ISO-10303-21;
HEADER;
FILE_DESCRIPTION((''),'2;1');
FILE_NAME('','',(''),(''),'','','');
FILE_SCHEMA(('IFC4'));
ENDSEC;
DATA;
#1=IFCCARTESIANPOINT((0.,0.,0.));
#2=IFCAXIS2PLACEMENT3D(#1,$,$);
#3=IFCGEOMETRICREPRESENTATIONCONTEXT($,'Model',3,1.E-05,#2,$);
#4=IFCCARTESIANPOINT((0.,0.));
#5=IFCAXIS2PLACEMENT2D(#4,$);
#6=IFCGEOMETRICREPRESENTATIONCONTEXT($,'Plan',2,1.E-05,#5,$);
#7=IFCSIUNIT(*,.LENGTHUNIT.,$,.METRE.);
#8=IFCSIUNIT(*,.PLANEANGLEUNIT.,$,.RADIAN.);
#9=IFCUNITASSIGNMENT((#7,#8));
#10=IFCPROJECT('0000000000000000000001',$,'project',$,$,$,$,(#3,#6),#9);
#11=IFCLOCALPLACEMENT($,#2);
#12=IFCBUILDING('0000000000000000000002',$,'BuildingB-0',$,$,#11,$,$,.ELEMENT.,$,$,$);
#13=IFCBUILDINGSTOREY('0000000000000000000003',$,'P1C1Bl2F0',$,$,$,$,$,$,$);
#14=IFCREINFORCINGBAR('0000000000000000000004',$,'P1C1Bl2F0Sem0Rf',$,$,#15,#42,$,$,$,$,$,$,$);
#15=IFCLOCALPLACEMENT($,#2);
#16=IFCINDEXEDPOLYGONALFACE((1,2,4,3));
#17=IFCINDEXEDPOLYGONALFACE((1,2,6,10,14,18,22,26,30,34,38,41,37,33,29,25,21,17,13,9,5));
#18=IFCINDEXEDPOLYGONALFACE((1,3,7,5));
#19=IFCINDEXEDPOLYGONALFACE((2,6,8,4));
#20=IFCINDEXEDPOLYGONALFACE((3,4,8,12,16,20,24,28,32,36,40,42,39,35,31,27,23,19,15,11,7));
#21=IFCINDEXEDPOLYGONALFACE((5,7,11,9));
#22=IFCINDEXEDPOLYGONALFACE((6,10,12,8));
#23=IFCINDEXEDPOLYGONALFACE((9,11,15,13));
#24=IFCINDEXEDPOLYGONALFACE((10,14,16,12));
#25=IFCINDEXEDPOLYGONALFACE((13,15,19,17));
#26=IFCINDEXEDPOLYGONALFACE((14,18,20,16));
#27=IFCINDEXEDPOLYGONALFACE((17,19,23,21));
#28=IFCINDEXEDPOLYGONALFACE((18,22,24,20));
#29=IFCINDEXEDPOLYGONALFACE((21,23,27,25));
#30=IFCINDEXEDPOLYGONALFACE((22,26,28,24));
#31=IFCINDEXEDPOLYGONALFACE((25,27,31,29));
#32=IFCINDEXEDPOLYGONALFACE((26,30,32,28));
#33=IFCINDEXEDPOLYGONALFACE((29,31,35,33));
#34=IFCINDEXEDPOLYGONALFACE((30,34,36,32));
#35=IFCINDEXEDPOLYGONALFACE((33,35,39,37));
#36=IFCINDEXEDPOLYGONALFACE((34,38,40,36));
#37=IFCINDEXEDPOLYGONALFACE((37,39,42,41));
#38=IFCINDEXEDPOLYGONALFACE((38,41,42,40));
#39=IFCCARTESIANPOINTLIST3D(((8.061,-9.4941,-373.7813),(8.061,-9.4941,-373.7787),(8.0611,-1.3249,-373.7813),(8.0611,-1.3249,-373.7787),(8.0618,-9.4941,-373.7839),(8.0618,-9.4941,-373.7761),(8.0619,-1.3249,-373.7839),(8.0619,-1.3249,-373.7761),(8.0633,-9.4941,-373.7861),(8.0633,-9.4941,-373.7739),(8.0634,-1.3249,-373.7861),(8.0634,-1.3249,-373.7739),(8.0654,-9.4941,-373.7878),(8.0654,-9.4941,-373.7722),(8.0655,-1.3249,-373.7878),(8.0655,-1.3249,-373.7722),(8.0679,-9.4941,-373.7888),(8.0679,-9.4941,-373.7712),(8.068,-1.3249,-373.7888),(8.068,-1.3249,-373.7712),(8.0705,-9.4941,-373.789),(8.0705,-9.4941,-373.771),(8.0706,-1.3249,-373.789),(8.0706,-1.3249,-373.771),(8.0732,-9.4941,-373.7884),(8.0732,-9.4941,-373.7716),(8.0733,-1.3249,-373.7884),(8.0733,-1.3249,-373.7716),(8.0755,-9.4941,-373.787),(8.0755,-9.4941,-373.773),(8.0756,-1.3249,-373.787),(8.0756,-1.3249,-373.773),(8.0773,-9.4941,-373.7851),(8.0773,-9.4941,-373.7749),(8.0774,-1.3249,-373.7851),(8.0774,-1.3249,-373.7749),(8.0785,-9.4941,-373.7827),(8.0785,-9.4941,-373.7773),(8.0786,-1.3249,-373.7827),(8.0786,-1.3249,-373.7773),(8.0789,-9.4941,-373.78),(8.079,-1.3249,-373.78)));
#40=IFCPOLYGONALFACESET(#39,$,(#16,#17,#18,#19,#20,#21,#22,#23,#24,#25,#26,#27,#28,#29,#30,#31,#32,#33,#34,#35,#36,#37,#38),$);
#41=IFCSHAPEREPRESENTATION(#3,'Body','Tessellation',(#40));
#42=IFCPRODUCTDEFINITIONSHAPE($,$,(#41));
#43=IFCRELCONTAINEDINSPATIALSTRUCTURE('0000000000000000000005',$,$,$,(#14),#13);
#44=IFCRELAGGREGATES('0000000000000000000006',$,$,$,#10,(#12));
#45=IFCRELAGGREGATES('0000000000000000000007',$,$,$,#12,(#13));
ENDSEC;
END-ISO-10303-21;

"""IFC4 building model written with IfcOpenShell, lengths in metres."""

from ifc_helpers import new_model, entity, si_unit, origin, origin_2d, place, context, project, spatial, element, save


model = new_model("IFC4")

# Units and contexts
model_context = context("Model", 3, precision=1e-05, world=origin())
plan_context = context("Plan", 2, precision=1e-05, world=origin_2d())
ifc_project = project(units=[si_unit("LENGTHUNIT", "METRE"), si_unit("PLANEANGLEUNIT", "RADIAN")], contexts=[model_context, plan_context])

# Building, storey
building_placement = place(None, origin())
building = spatial("IfcBuilding", under=ifc_project, at=building_placement, Name="BuildingB-0", CompositionType="ELEMENT")
storey = spatial("IfcBuildingStorey", under=building, Name="P1C1Bl2F0")

# Reinforcing bar
element("IfcReinforcingBar", 1, inside=storey, Name="P1C1Bl2F0Sem0Rf", context=model_context, shape_type="SweptSolid", body=[
    entity("IfcSurfaceCurveSweptAreaSolid", entity("IfcCircleProfileDef", "AREA", None, None, 0.009), None, entity("IfcPolyline", [entity("IfcCartesianPoint", [-8.07, 1.3249, 373.78]), entity("IfcCartesianPoint", [-8.0699, 9.4941, 373.78])]), None, None, entity("IfcPlane", entity("IfcAxis2Placement3D", entity("IfcCartesianPoint", [-8.07, 1.3249, 373.78]), entity("IfcDirection", [0.0, 0.0, 1.0]), entity("IfcDirection", [1.0, 0.0, 0.0])))),
])

save(model, "model.ifc")
